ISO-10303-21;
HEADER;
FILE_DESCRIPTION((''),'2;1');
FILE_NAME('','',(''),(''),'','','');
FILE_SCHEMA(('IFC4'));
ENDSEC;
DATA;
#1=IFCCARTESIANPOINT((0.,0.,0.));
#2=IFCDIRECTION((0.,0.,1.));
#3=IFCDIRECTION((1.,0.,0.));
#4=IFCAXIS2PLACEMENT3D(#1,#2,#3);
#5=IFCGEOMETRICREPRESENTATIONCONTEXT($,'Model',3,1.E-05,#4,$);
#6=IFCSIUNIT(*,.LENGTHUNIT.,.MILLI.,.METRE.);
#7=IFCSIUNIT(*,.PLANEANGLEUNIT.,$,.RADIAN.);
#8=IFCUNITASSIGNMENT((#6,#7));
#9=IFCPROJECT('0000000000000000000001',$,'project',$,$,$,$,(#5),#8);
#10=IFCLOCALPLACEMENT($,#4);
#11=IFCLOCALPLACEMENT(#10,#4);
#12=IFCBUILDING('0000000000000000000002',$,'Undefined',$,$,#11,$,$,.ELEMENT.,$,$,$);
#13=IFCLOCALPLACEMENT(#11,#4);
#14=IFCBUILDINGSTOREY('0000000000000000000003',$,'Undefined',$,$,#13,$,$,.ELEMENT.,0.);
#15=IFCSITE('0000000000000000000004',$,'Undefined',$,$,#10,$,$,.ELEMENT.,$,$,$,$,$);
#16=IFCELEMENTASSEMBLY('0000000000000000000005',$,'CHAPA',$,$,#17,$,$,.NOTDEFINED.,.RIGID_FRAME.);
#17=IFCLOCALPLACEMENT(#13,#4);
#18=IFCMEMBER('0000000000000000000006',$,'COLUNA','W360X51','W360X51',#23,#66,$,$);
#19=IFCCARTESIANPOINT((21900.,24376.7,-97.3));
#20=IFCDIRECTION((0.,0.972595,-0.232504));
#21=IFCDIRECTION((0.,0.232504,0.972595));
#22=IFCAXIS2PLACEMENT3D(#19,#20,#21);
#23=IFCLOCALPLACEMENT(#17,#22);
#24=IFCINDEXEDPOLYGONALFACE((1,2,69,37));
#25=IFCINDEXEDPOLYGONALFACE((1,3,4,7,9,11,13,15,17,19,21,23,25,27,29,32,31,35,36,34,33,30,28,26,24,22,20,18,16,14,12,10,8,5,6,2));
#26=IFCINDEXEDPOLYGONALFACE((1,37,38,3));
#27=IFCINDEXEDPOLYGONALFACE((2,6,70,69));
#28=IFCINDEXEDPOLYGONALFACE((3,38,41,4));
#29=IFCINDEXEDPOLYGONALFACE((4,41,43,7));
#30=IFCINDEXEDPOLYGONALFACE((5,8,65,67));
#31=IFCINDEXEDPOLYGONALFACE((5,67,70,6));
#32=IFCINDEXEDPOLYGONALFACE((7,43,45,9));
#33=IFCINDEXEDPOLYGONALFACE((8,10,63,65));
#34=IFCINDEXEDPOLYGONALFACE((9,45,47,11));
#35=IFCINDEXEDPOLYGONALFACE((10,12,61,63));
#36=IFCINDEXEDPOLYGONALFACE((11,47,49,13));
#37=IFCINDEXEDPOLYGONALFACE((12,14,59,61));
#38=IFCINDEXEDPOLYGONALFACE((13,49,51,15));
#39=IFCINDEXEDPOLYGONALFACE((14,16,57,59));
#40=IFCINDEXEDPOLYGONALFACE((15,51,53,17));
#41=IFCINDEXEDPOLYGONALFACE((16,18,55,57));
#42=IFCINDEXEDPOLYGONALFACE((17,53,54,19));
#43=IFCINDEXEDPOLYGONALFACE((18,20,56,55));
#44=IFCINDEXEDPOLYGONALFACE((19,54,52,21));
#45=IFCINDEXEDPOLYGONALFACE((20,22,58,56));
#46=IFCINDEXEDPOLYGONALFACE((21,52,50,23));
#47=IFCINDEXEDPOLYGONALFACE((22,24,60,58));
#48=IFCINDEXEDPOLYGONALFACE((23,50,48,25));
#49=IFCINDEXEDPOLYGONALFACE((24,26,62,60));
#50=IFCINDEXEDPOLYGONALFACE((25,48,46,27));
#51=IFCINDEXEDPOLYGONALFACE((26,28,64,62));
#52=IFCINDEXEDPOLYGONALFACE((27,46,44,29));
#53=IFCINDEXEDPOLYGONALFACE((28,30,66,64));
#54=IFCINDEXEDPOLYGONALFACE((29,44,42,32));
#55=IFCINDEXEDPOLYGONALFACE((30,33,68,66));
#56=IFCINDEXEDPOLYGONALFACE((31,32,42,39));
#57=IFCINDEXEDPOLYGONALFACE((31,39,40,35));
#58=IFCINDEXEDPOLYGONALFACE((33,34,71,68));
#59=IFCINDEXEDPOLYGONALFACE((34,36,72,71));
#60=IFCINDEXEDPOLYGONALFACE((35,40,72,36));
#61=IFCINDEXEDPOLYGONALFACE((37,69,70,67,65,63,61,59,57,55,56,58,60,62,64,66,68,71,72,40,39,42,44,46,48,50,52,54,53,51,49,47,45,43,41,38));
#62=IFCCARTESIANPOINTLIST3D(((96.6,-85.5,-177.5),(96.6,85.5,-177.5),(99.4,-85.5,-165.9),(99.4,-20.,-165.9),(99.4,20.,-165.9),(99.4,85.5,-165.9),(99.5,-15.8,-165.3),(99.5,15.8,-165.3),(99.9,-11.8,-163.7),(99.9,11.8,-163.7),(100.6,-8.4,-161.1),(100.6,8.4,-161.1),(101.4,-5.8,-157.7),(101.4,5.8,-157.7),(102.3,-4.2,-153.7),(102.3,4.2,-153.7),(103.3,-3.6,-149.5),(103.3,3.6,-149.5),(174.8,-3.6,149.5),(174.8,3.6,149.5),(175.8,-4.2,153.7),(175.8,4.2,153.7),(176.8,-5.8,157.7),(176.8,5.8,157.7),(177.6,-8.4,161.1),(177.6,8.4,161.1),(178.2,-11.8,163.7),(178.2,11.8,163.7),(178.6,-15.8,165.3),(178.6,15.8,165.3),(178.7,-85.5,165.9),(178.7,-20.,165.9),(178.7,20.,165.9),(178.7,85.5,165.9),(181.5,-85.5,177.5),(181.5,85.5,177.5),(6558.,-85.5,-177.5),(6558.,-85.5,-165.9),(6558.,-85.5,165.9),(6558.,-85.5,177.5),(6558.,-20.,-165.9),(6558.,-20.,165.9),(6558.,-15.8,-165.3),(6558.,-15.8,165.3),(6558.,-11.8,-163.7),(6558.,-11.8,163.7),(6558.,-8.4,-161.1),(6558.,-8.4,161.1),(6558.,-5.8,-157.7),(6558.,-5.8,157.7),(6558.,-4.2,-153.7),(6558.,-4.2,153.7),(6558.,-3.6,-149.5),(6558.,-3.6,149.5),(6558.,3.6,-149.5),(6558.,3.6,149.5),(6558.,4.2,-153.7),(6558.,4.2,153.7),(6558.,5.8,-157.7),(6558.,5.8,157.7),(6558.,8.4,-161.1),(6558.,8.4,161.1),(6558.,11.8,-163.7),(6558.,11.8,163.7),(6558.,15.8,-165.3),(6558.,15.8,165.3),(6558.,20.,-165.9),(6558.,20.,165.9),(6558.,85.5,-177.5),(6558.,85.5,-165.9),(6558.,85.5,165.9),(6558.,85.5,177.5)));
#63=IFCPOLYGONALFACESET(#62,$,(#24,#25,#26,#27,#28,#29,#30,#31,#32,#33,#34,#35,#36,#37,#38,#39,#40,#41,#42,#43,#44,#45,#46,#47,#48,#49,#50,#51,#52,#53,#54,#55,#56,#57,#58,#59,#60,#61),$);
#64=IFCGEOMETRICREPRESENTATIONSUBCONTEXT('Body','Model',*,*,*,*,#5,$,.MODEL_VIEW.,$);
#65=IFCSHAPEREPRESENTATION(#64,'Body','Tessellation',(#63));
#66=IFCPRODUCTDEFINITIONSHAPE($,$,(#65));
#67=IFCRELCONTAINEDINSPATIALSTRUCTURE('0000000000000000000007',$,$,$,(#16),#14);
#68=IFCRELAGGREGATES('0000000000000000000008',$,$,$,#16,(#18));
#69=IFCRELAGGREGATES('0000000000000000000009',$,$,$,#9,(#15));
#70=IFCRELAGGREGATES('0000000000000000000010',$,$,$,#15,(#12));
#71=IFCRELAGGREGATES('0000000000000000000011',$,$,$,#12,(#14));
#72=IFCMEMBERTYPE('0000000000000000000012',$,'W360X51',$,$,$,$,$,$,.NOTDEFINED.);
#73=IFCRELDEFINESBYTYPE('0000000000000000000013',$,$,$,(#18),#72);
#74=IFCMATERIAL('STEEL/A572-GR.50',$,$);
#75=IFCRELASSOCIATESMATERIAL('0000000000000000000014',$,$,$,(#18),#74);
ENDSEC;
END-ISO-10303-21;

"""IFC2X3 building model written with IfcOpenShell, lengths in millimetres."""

from ifc_helpers import new_model, si_unit, frame, origin_with_axes, origin_2d_with_axis, place, context, subcontext, project, spatial, i_section, extrude, clip, halfspace, material, type_object, element, aggregate, save


model = new_model("IFC2X3")

# Units and contexts
model_context = context("Model", 3, precision=1e-05, world=origin_with_axes())
body_context = subcontext(model_context, "Body", "Model", "MODEL_VIEW")
ifc_project = project(units=[si_unit("LENGTHUNIT", "METRE", prefix="MILLI"), si_unit("PLANEANGLEUNIT", "RADIAN")], contexts=[model_context])

# Site, building, storey
site_placement = place(None, origin_with_axes())
site = spatial("IfcSite", under=ifc_project, at=site_placement, Name="Undefined", CompositionType="ELEMENT")
building_placement = place(site_placement, origin_with_axes())
building = spatial("IfcBuilding", under=site, at=building_placement, Name="Undefined", CompositionType="ELEMENT")
storey_placement = place(building_placement, origin_with_axes())
storey = spatial("IfcBuildingStorey", under=building, at=storey_placement, Name="Undefined", CompositionType="ELEMENT", Elevation=0.0)

# Element assembly, member
assembly_1_placement = place(storey_placement, origin_with_axes())
assembly_1 = element("IfcElementAssembly", 1, at=assembly_1_placement, inside=storey, Name="CHAPA", AssemblyPlace="NOTDEFINED", PredefinedType="RIGID_FRAME")
ifc_material_1 = material(Name="STEEL/A572-GR.50")
member_type = type_object("IfcMemberType", Name="W360X51", PredefinedType="NOTDEFINED")
member_placement = place(assembly_1_placement, frame((21900.0, 24376.7, -97.3), z_axis=(0.0, 0.972595, -0.232504), x_axis=(0.0, 0.232504, 0.972595)))
member = element("IfcMember", 2, at=member_placement, type_object=member_type, material=ifc_material_1, Name="COLUNA", Description="W360X51", ObjectType="W360X51", context=body_context, shape_type="Clipping", body=[
    clip(clip(extrude(i_section(OverallWidth=171.0, OverallDepth=355.0, WebThickness=7.2, FlangeThickness=11.6, FilletRadius=16.4, at=origin_2d_with_axis()), frame((6558.0, 0.0, 0.0), z_axis=(-1.0, 0.0, 0.0), x_axis=(0.0, -1.0, 0.0)), (0.0, 0.0, 1.0), 6542.9), halfspace(frame((94.5, -85.5, -186.3), z_axis=(-0.972595, 0.0, 0.232504), x_axis=(0.0, 1.0, 0.0)), False)), halfspace(frame((96.6, 0.0, -177.5), z_axis=(0.972595, 0.0, -0.232504), x_axis=(0.0, -1.0, 0.0)), True)),
])

aggregate(assembly_1, [member])

save(model, "model.ifc")
